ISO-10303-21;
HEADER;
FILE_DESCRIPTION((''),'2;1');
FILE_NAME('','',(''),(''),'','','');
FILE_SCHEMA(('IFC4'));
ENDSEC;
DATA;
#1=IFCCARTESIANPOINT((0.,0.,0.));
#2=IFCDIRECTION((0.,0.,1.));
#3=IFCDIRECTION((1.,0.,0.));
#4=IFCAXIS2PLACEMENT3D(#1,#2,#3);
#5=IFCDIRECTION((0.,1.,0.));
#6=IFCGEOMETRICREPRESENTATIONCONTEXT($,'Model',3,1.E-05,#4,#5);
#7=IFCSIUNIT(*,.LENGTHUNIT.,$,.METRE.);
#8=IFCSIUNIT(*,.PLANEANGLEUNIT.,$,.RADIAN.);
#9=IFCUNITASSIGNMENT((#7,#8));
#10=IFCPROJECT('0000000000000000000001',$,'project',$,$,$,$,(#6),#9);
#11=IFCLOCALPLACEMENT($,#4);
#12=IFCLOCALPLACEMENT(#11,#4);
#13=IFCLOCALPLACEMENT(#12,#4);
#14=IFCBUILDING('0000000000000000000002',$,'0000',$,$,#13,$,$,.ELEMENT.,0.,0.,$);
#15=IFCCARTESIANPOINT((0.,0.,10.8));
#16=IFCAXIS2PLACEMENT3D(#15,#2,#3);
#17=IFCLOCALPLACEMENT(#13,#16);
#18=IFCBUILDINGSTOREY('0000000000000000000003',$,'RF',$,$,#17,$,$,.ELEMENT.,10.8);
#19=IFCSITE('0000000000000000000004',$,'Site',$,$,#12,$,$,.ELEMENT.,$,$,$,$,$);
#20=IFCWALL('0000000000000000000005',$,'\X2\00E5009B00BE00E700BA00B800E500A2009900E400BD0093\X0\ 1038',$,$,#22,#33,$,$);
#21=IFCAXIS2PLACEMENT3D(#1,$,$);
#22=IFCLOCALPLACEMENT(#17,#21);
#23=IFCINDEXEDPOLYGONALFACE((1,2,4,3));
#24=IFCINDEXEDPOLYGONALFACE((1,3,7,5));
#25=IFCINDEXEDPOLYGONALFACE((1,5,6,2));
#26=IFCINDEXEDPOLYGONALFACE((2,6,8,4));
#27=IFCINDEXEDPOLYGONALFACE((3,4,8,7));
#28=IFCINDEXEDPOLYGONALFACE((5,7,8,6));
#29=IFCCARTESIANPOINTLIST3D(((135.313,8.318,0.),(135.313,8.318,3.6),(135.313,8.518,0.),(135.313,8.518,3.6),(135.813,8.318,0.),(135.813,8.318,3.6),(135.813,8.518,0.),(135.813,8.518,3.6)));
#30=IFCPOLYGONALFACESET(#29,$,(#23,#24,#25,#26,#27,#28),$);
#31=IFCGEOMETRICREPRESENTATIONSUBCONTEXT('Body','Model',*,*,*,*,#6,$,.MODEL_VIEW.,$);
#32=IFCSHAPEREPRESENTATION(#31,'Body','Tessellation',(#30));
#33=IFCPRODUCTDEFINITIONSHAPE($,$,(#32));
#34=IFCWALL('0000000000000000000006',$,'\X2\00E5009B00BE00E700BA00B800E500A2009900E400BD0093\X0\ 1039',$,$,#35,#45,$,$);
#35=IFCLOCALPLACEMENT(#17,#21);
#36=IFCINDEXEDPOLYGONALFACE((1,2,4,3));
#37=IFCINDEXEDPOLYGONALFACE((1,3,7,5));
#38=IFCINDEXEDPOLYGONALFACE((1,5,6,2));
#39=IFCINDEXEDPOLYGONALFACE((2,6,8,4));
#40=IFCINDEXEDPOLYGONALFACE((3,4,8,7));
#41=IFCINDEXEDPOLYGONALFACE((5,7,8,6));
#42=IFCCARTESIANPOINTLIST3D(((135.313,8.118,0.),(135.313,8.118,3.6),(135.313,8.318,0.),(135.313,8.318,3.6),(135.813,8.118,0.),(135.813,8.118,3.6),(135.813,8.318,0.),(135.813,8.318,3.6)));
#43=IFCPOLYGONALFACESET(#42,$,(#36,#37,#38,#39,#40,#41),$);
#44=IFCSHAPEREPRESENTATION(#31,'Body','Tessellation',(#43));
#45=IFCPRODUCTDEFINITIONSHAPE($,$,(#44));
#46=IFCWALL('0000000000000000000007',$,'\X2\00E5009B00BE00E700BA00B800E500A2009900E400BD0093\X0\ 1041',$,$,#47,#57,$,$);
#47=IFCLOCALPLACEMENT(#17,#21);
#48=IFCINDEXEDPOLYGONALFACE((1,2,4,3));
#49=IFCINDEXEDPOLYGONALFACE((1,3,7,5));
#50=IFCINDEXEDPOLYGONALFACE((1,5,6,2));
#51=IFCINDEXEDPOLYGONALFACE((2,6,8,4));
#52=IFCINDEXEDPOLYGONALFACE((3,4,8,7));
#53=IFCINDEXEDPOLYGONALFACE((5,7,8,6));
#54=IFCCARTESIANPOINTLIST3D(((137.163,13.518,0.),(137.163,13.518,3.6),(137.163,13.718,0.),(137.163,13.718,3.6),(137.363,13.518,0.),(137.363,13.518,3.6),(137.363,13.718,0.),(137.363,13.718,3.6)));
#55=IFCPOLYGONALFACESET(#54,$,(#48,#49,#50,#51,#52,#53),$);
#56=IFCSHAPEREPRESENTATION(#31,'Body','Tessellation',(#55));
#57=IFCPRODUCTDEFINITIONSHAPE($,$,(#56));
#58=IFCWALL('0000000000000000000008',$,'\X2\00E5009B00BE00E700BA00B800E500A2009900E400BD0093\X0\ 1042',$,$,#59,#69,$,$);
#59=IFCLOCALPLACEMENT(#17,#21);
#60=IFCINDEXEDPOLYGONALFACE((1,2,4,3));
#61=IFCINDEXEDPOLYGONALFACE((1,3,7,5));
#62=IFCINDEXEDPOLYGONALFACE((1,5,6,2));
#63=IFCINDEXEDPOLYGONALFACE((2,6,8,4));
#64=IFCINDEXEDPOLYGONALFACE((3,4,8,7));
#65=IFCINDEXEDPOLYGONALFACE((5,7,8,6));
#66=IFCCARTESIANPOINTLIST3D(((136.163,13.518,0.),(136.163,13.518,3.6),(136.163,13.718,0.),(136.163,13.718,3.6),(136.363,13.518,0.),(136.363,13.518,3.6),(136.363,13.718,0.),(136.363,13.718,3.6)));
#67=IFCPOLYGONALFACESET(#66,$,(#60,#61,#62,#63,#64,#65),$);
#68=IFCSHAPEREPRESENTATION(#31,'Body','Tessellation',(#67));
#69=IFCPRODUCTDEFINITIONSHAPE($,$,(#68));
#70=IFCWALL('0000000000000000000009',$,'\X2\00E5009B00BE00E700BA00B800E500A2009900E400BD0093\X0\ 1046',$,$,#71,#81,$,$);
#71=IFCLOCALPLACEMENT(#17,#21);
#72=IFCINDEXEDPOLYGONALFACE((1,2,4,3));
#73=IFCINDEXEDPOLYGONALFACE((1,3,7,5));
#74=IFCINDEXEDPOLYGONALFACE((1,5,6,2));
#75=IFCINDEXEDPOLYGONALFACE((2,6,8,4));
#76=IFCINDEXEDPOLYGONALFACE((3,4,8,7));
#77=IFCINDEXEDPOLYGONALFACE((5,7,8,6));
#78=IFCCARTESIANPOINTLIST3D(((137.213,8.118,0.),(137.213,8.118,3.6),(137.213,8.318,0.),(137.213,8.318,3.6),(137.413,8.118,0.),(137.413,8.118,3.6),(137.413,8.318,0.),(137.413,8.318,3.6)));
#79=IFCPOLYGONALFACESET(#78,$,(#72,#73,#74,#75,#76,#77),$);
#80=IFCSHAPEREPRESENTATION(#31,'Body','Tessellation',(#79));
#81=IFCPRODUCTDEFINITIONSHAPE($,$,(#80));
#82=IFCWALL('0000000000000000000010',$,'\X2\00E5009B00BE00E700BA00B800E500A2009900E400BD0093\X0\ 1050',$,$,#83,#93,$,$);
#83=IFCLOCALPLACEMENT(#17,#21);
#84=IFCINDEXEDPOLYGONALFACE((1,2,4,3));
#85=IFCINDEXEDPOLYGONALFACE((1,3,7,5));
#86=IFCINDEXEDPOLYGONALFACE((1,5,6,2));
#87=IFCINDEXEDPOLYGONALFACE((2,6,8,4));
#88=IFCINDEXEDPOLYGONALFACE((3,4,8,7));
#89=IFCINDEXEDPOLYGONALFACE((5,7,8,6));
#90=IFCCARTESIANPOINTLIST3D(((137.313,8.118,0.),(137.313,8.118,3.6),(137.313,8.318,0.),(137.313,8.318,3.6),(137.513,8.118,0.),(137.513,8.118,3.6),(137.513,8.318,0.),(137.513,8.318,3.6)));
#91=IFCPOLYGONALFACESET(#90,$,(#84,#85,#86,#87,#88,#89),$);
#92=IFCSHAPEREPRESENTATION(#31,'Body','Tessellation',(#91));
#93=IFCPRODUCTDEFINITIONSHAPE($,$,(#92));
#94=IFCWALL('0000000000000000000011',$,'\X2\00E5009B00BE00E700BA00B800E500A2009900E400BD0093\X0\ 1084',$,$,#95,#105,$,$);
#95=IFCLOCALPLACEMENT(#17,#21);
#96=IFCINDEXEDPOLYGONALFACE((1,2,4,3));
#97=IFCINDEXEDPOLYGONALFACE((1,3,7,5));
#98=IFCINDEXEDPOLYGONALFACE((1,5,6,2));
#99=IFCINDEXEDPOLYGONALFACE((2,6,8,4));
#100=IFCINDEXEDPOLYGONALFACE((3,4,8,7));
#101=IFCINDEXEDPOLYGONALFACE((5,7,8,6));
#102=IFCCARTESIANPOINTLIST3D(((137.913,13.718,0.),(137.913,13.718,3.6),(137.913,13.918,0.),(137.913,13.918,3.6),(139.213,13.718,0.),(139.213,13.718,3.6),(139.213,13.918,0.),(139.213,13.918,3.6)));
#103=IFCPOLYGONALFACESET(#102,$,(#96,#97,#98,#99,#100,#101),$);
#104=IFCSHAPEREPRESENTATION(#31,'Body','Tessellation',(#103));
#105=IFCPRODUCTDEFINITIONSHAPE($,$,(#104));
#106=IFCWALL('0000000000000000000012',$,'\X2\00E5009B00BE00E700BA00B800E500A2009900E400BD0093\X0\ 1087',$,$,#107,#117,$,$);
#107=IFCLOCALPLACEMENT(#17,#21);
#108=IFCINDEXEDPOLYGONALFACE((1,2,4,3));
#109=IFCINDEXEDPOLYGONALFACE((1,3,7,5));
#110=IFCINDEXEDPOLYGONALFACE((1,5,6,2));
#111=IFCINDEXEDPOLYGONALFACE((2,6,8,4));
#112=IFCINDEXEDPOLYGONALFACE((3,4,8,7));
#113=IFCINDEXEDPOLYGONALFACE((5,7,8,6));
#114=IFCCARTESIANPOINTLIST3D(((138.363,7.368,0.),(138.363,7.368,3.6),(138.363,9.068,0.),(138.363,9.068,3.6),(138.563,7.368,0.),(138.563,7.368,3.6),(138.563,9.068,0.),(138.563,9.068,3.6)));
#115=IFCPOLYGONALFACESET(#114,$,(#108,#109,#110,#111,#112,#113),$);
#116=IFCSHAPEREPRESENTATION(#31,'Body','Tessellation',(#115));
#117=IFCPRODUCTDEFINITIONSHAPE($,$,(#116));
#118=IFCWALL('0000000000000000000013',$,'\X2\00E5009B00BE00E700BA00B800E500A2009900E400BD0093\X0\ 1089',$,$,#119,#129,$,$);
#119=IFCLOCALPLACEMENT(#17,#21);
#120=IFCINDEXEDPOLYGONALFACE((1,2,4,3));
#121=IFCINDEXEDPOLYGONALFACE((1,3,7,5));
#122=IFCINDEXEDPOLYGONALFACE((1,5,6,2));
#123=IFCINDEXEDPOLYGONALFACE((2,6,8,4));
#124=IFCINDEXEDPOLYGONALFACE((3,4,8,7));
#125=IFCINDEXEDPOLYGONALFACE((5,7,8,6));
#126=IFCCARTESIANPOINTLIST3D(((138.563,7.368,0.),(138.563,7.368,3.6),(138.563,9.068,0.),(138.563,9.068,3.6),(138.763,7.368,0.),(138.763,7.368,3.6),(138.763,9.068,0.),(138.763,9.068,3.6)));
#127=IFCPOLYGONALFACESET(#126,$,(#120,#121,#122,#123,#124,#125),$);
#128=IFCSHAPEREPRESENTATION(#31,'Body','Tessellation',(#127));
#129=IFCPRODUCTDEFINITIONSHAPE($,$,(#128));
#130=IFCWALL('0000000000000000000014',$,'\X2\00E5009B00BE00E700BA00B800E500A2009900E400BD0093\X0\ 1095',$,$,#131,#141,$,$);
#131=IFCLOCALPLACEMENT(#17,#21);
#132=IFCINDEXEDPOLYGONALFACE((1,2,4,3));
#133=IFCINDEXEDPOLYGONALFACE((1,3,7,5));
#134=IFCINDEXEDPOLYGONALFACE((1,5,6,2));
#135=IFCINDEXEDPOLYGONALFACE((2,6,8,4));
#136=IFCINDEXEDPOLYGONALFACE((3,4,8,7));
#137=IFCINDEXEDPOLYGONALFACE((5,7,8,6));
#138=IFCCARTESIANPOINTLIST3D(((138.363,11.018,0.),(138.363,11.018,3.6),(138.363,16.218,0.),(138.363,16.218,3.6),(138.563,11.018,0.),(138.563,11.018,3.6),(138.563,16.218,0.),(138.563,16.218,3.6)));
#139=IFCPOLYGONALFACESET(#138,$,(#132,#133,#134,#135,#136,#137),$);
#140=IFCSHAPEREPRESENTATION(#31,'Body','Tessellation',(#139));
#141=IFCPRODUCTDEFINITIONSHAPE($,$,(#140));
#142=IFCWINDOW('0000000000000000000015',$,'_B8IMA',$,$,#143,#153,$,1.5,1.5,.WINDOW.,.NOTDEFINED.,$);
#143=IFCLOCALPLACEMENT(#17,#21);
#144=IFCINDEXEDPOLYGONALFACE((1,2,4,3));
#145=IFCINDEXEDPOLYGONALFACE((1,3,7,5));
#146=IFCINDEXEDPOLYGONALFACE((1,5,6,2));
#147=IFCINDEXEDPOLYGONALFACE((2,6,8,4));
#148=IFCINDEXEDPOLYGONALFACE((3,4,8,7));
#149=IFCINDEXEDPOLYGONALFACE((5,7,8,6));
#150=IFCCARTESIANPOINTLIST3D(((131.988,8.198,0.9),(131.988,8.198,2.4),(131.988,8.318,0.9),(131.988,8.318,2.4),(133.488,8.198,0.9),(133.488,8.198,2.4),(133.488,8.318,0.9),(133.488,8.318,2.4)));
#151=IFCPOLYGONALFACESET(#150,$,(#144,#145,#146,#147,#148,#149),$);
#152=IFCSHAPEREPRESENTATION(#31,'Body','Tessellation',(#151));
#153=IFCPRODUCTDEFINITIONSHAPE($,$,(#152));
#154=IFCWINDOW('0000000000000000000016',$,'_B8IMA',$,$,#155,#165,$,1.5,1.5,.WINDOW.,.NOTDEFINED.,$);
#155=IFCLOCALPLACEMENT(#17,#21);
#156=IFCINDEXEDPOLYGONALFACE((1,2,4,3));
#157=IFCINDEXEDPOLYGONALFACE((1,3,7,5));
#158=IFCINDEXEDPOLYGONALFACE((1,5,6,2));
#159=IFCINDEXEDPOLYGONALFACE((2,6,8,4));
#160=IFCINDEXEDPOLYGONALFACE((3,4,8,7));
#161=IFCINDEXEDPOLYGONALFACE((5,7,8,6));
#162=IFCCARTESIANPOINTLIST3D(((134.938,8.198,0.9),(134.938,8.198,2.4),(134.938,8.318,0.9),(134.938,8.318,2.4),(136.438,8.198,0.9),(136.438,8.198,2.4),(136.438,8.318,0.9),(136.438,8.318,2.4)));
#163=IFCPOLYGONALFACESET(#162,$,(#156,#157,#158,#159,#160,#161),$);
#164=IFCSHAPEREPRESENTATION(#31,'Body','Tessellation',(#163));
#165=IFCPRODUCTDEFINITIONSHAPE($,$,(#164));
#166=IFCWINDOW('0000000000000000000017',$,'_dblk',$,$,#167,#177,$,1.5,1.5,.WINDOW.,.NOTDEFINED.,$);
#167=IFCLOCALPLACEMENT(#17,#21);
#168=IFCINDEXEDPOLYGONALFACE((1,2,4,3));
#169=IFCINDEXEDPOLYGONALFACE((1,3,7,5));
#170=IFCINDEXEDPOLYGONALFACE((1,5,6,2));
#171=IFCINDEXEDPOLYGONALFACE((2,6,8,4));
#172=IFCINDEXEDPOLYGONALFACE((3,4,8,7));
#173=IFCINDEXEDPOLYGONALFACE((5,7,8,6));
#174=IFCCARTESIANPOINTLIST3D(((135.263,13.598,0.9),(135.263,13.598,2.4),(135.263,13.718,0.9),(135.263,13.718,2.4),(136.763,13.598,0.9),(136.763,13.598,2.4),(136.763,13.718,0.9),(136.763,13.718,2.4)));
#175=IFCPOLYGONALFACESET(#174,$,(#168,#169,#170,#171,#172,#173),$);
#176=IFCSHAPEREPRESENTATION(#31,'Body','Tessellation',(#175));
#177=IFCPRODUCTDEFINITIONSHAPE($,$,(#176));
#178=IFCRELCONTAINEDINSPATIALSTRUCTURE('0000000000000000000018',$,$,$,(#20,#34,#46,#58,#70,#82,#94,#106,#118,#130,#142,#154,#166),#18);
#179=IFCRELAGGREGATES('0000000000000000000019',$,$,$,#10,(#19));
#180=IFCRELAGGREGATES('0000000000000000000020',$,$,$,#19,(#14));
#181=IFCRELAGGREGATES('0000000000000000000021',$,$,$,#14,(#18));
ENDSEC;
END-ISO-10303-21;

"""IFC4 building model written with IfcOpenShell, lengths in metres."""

from ifc_helpers import new_model, si_unit, direction, frame, frame_2d, origin_with_axes, place, context, subcontext, project, spatial, rectangle, extrude, element, save


model = new_model("IFC4")

# Units and contexts
model_context = context("Model", 3, precision=1e-05, world=origin_with_axes(), true_north=direction((0.0, 1.0, 0.0)))
body_context = subcontext(model_context, "Body", "Model", "MODEL_VIEW")
ifc_project = project(units=[si_unit("LENGTHUNIT", "METRE"), si_unit("PLANEANGLEUNIT", "RADIAN")], contexts=[model_context])

# Site, building, storey
placement = place(None, origin_with_axes())
site_placement = place(placement, origin_with_axes())
site = spatial("IfcSite", under=ifc_project, at=site_placement, Name="Site", CompositionType="ELEMENT")
building_placement = place(site_placement, origin_with_axes())
building = spatial("IfcBuilding", under=site, at=building_placement, Name="0000", CompositionType="ELEMENT", ElevationOfRefHeight=0.0, ElevationOfTerrain=0.0)
storey_placement = place(building_placement, frame((0.0, 0.0, 10.8), z_axis=(0.0, 0.0, 1.0), x_axis=(1.0, 0.0, 0.0)))
storey = spatial("IfcBuildingStorey", under=building, at=storey_placement, Name="RF", CompositionType="ELEMENT", Elevation=10.8)

# Walls
for number, where, z_axis, x_axis, name in (
    (1, (135.563, 8.418, 0.0), (0.0, 0.0, 1.0), (-1.0, 0.0, 0.0), "å\u009b¾çº¸å¢\u0099ä½\u0093 1038"),
    (2, (135.563, 8.218, 0.0), (0.0, 0.0, 1.0), (-1.0, 0.0, 0.0), "å\u009b¾çº¸å¢\u0099ä½\u0093 1039"),
):
    element("IfcWall", number, at=place(storey_placement, frame(where, z_axis=z_axis, x_axis=x_axis)), inside=storey, Name=name, context=body_context, shape_type="SweptSolid", body=[
        extrude(rectangle(XDim=0.5, YDim=0.2, at=frame_2d((0.0, 0.0), x_axis=(1.0, 0.0, 0.0))), frame((0.0, 0.0, 0.0), z_axis=(0.0, 0.0, 1.0)), (0.0, 0.0, 1.0), 3.6),
    ])
for number, where, z_axis, x_axis, name in (
    (3, (137.263, 13.618, 0.0), (0.0, 0.0, 1.0), (0.0, 1.0, 0.0), "å\u009b¾çº¸å¢\u0099ä½\u0093 1041"),
    (4, (136.263, 13.618, 0.0), (0.0, 0.0, 1.0), (0.0, 1.0, 0.0), "å\u009b¾çº¸å¢\u0099ä½\u0093 1042"),
    (5, (137.313, 8.218, 0.0), (0.0, 0.0, 1.0), (0.0, 1.0, 0.0), "å\u009b¾çº¸å¢\u0099ä½\u0093 1046"),
    (6, (137.413, 8.218, 0.0), (0.0, 0.0, 1.0), (0.0, -1.0, 0.0), "å\u009b¾çº¸å¢\u0099ä½\u0093 1050"),
):
    element("IfcWall", number, at=place(storey_placement, frame(where, z_axis=z_axis, x_axis=x_axis)), inside=storey, Name=name, context=body_context, shape_type="SweptSolid", body=[
        extrude(rectangle(XDim=0.2, YDim=0.2, at=frame_2d((0.0, 0.0), x_axis=(1.0, 0.0, 0.0))), frame((0.0, 0.0, 0.0), z_axis=(0.0, 0.0, 1.0)), (0.0, 0.0, 1.0), 3.6),
    ])
wall_1_placement = place(storey_placement, frame((138.563, 13.818, 0.0), z_axis=(0.0, 0.0, 1.0), x_axis=(1.0, 0.0, 0.0)))
element("IfcWall", 7, at=wall_1_placement, inside=storey, Name="å\u009b¾çº¸å¢\u0099ä½\u0093 1084", context=body_context, shape_type="SweptSolid", body=[
    extrude(rectangle(XDim=1.3, YDim=0.2, at=frame_2d((0.0, 0.0), x_axis=(1.0, 0.0, 0.0))), frame((0.0, 0.0, 0.0), z_axis=(0.0, 0.0, 1.0)), (0.0, 0.0, 1.0), 3.6),
])
for number, where, z_axis, x_axis, name in (
    (8, (138.463, 8.218, 0.0), (0.0, 0.0, 1.0), (0.0, -1.0, 0.0), "å\u009b¾çº¸å¢\u0099ä½\u0093 1087"),
    (9, (138.663, 8.218, 0.0), (0.0, 0.0, 1.0), (0.0, -1.0, 0.0), "å\u009b¾çº¸å¢\u0099ä½\u0093 1089"),
):
    element("IfcWall", number, at=place(storey_placement, frame(where, z_axis=z_axis, x_axis=x_axis)), inside=storey, Name=name, context=body_context, shape_type="SweptSolid", body=[
        extrude(rectangle(XDim=1.7, YDim=0.2, at=frame_2d((0.0, 0.0), x_axis=(1.0, 0.0, 0.0))), frame((0.0, 0.0, 0.0), z_axis=(0.0, 0.0, 1.0)), (0.0, 0.0, 1.0), 3.6),
    ])
wall_2_placement = place(storey_placement, frame((138.463, 13.618, 0.0), z_axis=(0.0, 0.0, 1.0), x_axis=(0.0, -1.0, 0.0)))
element("IfcWall", 10, at=wall_2_placement, inside=storey, Name="å\u009b¾çº¸å¢\u0099ä½\u0093 1095", context=body_context, shape_type="SweptSolid", body=[
    extrude(rectangle(XDim=5.2, YDim=0.2, at=frame_2d((0.0, 0.0), x_axis=(1.0, 0.0, 0.0))), frame((0.0, 0.0, 0.0), z_axis=(0.0, 0.0, 1.0)), (0.0, 0.0, 1.0), 3.6),
])

# Windows
for number, where, z_axis, x_axis, name in (
    (11, (132.738, 8.258, 0.9), (0.0, 0.0, 1.0), (1.0, 0.0, 0.0), "_B8IMA"),
    (12, (135.688, 8.258, 0.9), (0.0, 0.0, 1.0), (1.0, 0.0, 0.0), "_B8IMA"),
    (13, (136.013, 13.658, 0.9), (0.0, 0.0, 1.0), (1.0, 0.0, 0.0), "_dblk"),
):
    element("IfcWindow", number, at=place(storey_placement, frame(where, z_axis=z_axis, x_axis=x_axis)), inside=storey, Name=name, OverallHeight=1.5, OverallWidth=1.5, PartitioningType="NOTDEFINED", PredefinedType="WINDOW", context=body_context, shape_type="SweptSolid", body=[
        extrude(rectangle(XDim=1.5, YDim=0.12, at=frame_2d((0.0, 0.0), x_axis=(1.0, 0.0, 0.0))), frame((0.0, 0.0, 0.0), z_axis=(0.0, 0.0, 1.0)), (0.0, 0.0, 1.0), 1.5),
    ])

save(model, "model.ifc")
